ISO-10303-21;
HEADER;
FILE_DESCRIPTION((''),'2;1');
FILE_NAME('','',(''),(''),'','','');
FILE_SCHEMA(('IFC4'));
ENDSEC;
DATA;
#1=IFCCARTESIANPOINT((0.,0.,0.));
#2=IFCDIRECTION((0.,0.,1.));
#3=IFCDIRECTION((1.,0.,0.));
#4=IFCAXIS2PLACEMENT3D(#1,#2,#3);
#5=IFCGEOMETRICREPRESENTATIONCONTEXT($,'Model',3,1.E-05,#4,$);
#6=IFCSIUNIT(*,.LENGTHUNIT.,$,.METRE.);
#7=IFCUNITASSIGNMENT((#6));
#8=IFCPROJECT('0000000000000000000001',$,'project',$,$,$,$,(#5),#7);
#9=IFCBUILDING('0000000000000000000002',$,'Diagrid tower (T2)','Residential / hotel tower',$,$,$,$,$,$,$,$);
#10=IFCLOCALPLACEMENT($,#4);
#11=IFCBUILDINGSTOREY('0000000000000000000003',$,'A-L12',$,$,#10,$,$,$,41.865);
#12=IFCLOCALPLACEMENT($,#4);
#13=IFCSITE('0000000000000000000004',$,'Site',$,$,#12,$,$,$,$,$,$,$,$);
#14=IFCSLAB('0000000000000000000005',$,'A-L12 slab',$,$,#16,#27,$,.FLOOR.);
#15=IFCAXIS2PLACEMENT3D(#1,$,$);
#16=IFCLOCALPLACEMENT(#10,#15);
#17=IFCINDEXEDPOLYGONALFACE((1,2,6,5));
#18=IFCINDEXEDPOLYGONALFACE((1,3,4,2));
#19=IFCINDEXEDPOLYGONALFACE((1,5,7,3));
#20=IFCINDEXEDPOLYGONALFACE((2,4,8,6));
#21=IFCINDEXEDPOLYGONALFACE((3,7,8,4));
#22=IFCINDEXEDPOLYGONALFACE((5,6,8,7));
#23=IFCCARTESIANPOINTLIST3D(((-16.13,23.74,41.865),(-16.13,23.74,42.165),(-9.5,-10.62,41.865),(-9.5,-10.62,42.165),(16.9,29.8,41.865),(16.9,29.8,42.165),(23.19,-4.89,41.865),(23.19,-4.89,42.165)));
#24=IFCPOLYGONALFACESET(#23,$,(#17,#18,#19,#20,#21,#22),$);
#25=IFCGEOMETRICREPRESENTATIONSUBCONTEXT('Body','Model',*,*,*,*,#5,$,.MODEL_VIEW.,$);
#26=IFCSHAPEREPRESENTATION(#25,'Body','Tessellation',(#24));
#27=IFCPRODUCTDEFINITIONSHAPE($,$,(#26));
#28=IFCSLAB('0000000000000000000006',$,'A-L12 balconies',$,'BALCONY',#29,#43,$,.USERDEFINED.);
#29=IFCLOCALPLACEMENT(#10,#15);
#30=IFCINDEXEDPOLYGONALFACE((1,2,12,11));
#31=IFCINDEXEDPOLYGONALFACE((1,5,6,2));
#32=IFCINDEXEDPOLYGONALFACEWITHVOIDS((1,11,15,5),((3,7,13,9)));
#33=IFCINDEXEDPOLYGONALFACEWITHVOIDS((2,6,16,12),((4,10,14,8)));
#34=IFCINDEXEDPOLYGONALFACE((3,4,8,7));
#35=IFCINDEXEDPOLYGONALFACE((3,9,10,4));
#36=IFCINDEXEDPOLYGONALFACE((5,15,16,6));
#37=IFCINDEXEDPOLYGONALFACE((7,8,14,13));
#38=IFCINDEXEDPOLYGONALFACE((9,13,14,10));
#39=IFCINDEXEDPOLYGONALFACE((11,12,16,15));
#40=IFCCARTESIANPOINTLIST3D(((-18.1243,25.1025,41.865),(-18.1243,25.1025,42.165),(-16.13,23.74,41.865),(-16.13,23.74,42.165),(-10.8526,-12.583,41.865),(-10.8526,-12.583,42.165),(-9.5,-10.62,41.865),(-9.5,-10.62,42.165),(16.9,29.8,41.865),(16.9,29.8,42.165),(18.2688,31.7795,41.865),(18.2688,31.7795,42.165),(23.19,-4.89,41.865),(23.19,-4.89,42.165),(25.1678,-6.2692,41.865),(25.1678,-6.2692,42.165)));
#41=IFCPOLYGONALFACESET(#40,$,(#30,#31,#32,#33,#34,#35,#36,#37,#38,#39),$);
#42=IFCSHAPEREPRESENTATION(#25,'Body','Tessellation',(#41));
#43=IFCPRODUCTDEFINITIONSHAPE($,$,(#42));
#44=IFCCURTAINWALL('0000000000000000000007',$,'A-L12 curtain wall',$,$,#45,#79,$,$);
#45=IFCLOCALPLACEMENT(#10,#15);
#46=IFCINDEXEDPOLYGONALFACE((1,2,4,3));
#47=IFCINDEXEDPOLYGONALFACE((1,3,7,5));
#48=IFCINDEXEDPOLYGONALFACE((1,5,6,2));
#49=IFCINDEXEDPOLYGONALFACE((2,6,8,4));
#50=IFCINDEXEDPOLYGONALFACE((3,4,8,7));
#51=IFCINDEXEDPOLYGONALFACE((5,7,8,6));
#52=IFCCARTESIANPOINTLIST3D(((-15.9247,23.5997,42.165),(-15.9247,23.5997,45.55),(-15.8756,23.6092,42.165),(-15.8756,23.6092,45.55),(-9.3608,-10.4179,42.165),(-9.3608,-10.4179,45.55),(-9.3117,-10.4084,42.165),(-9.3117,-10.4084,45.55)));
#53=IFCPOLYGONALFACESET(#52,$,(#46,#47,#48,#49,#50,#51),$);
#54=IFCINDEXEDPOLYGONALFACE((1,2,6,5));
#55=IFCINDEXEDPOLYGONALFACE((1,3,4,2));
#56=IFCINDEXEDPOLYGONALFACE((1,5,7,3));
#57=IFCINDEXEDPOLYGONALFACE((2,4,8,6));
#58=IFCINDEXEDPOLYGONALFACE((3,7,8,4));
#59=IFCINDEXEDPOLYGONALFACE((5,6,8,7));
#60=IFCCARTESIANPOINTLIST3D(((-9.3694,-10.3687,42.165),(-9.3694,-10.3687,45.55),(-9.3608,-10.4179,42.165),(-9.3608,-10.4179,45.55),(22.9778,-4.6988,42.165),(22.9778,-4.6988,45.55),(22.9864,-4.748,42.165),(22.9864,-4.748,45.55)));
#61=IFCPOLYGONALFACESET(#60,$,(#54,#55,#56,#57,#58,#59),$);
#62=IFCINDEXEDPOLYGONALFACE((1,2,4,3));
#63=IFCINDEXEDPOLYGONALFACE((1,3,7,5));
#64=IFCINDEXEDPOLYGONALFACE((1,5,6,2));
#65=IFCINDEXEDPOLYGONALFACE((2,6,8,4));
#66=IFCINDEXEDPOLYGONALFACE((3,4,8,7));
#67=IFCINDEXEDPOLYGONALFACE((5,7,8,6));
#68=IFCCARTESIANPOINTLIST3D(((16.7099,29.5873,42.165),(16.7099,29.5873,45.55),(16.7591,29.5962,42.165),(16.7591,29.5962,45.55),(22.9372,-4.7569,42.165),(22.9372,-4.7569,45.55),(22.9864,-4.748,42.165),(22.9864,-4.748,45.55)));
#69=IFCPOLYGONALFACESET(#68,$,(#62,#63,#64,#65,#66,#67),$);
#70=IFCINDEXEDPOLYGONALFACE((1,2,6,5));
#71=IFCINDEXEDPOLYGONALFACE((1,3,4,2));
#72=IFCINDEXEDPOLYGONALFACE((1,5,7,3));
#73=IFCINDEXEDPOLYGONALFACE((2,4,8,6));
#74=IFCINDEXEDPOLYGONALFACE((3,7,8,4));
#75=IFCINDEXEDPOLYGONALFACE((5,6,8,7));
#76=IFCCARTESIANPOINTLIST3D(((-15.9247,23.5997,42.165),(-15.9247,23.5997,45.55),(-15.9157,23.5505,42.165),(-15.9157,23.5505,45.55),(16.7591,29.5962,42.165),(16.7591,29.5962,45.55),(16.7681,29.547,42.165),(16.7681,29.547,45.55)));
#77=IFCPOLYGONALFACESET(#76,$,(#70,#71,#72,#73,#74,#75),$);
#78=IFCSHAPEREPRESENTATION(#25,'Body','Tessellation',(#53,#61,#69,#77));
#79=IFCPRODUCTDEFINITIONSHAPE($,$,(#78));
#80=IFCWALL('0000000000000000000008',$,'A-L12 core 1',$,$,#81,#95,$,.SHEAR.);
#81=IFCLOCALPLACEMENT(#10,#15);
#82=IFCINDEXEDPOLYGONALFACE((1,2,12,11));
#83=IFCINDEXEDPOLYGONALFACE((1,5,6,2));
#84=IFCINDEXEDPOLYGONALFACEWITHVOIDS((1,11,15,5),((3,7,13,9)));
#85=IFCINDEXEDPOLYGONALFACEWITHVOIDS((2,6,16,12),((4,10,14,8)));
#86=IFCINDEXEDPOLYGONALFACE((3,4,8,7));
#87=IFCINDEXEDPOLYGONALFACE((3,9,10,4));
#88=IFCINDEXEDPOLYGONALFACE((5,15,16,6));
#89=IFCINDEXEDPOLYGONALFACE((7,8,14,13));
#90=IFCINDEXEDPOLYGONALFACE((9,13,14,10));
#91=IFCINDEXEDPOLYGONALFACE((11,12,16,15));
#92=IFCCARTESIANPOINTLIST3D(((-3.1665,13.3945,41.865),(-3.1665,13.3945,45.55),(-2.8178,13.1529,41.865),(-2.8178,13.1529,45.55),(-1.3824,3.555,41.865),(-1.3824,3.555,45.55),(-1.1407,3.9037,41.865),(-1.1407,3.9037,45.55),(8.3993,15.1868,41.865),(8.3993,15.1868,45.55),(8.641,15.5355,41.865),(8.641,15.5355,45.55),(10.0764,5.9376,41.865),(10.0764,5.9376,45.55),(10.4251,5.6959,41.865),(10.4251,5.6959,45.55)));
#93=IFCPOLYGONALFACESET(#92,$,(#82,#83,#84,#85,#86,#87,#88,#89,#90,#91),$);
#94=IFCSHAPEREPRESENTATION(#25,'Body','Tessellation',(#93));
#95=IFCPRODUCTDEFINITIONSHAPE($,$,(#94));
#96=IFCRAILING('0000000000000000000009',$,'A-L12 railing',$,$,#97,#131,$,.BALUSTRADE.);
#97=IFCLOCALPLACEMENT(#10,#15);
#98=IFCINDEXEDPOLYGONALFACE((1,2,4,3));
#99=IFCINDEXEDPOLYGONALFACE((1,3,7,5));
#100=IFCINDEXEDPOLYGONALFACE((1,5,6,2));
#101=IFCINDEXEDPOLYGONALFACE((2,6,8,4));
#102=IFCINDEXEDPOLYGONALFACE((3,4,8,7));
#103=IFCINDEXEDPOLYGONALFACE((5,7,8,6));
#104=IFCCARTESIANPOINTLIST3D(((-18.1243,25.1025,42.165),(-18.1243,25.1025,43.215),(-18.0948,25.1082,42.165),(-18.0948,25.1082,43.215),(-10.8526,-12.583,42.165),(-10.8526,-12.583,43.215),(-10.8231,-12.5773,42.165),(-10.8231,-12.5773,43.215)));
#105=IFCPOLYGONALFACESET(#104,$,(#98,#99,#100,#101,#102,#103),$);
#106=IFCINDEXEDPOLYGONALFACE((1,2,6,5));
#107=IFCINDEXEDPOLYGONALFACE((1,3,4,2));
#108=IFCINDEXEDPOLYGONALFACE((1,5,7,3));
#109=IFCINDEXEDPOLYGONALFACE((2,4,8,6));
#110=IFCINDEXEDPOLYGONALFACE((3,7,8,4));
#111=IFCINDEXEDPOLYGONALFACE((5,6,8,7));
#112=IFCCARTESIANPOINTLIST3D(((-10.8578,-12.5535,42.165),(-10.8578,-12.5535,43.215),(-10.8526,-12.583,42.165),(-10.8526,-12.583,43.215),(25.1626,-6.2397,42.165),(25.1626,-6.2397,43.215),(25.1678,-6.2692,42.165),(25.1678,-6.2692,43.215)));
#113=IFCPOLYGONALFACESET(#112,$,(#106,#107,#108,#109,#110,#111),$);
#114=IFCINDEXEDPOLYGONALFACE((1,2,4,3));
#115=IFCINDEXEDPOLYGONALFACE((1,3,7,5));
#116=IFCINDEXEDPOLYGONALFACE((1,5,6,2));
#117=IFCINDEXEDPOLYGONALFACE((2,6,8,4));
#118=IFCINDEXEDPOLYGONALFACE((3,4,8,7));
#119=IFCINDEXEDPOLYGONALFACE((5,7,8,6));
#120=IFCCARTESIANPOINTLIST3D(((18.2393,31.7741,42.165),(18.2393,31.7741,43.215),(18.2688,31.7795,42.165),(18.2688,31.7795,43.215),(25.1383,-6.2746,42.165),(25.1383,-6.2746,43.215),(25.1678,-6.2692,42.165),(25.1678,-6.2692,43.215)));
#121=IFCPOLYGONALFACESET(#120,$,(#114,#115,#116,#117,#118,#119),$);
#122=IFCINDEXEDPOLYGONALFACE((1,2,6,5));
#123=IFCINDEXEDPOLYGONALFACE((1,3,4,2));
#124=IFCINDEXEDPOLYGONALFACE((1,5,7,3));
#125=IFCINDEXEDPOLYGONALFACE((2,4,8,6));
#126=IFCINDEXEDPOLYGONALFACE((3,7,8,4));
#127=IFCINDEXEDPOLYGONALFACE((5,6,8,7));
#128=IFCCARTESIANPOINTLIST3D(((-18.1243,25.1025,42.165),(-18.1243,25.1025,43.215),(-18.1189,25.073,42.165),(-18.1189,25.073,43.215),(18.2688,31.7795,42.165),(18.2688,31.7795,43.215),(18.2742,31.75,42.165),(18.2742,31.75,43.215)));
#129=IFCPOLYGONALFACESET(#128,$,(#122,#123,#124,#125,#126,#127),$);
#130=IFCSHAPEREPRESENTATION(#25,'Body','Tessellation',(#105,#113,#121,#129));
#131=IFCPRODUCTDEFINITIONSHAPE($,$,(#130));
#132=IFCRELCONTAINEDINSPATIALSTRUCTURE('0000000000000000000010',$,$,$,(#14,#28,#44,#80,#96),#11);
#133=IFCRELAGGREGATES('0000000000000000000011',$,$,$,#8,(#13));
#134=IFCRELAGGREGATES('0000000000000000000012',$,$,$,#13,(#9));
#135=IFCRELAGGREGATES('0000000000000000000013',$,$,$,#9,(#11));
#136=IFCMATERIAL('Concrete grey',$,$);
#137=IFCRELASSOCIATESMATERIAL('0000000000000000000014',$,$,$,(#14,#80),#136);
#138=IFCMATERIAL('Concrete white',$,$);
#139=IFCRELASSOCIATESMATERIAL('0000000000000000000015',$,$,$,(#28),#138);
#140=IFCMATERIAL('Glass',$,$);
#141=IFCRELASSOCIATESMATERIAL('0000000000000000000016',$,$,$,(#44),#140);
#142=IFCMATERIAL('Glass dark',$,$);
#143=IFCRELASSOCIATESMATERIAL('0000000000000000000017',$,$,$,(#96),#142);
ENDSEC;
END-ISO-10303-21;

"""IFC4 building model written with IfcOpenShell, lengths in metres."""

from ifc_helpers import new_model, si_unit, frame, origin_with_axes, place, context, subcontext, project, spatial, polyline, outline, extrude, material, element, save


model = new_model("IFC4")

# Units and contexts
model_context = context("Model", 3, precision=1e-05, world=origin_with_axes())
body_context = subcontext(model_context, "Body", "Model", "MODEL_VIEW")
ifc_project = project(units=[si_unit("LENGTHUNIT", "METRE")], contexts=[model_context])

# Site, building, storey
site_placement = place(None, origin_with_axes())
site = spatial("IfcSite", under=ifc_project, at=site_placement, Name="Site")
building = spatial("IfcBuilding", under=site, Name="Diagrid tower (T2)", Description="Residential / hotel tower")
storey_placement = place(None, origin_with_axes())
storey = spatial("IfcBuildingStorey", under=building, at=storey_placement, Name="A-L12", Elevation=41.865)

# Slabs
ifc_material_1 = material(Name="Concrete grey")
slab_1_placement = place(storey_placement, origin_with_axes())
element("IfcSlab", 1, at=slab_1_placement, inside=storey, material=ifc_material_1, Name="A-L12 slab", PredefinedType="FLOOR", context=body_context, shape_type="SweptSolid", body=[
    extrude(outline(polyline([(-16.13, 23.74), (-9.5, -10.62), (23.19, -4.89), (16.9, 29.8), (-16.13, 23.74)])), frame((0.0, 0.0, 41.865), z_axis=(0.0, 0.0, 1.0), x_axis=(1.0, 0.0, 0.0)), (0.0, 0.0, 1.0), 0.3),
])
ifc_material_2 = material(Name="Concrete white")
slab_2_placement = place(storey_placement, origin_with_axes())
element("IfcSlab", 2, at=slab_2_placement, inside=storey, material=ifc_material_2, Name="A-L12 balconies", ObjectType="BALCONY", PredefinedType="USERDEFINED", context=body_context, shape_type="SweptSolid", body=[
    extrude(outline(polyline([(-18.1243, 25.1025), (-10.8526, -12.583), (25.1678, -6.2692), (18.2688, 31.7795), (-18.1243, 25.1025)]), holes=[polyline([(-16.13, 23.74), (-9.5, -10.62), (23.19, -4.89), (16.9, 29.8), (-16.13, 23.74)])]), frame((0.0, 0.0, 41.865), z_axis=(0.0, 0.0, 1.0), x_axis=(1.0, 0.0, 0.0)), (0.0, 0.0, 1.0), 0.3),
])

# Curtain wall
ifc_material_3 = material(Name="Glass")
curtain_wall_placement = place(storey_placement, origin_with_axes())
element("IfcCurtainWall", 3, at=curtain_wall_placement, inside=storey, material=ifc_material_3, Name="A-L12 curtain wall", context=body_context, shape_type="SweptSolid", body=[
    extrude(outline(polyline([(-15.9247, 23.5997), (-9.3608, -10.4179), (-9.3117, -10.4084), (-15.8756, 23.6092), (-15.9247, 23.5997)])), frame((0.0, 0.0, 42.165), z_axis=(0.0, 0.0, 1.0), x_axis=(1.0, 0.0, 0.0)), (0.0, 0.0, 1.0), 3.385),
    extrude(outline(polyline([(-9.3608, -10.4179), (22.9864, -4.748), (22.9778, -4.6988), (-9.3694, -10.3687), (-9.3608, -10.4179)])), frame((0.0, 0.0, 42.165), z_axis=(0.0, 0.0, 1.0), x_axis=(1.0, 0.0, 0.0)), (0.0, 0.0, 1.0), 3.385),
    extrude(outline(polyline([(22.9864, -4.748), (16.7591, 29.5962), (16.7099, 29.5873), (22.9372, -4.7569), (22.9864, -4.748)])), frame((0.0, 0.0, 42.165), z_axis=(0.0, 0.0, 1.0), x_axis=(1.0, 0.0, 0.0)), (0.0, 0.0, 1.0), 3.385),
    extrude(outline(polyline([(16.7591, 29.5962), (-15.9247, 23.5997), (-15.9157, 23.5505), (16.7681, 29.547), (16.7591, 29.5962)])), frame((0.0, 0.0, 42.165), z_axis=(0.0, 0.0, 1.0), x_axis=(1.0, 0.0, 0.0)), (0.0, 0.0, 1.0), 3.385),
])

# Wall
wall_placement = place(storey_placement, origin_with_axes())
element("IfcWall", 4, at=wall_placement, inside=storey, material=ifc_material_1, Name="A-L12 core 1", PredefinedType="SHEAR", context=body_context, shape_type="SweptSolid", body=[
    extrude(outline(polyline([(10.4251, 5.6959), (8.641, 15.5355), (-3.1665, 13.3945), (-1.3824, 3.555), (10.4251, 5.6959)]), holes=[polyline([(10.0764, 5.9376), (8.3993, 15.1868), (-2.8178, 13.1529), (-1.1407, 3.9037), (10.0764, 5.9376)])]), frame((0.0, 0.0, 41.865), z_axis=(0.0, 0.0, 1.0), x_axis=(1.0, 0.0, 0.0)), (0.0, 0.0, 1.0), 3.685),
])

# Railing
ifc_material_4 = material(Name="Glass dark")
railing_placement = place(storey_placement, origin_with_axes())
element("IfcRailing", 5, at=railing_placement, inside=storey, material=ifc_material_4, Name="A-L12 railing", PredefinedType="BALUSTRADE", context=body_context, shape_type="SweptSolid", body=[
    extrude(outline(polyline([(-18.1243, 25.1025), (-10.8526, -12.583), (-10.8231, -12.5773), (-18.0948, 25.1082), (-18.1243, 25.1025)])), frame((0.0, 0.0, 42.165), z_axis=(0.0, 0.0, 1.0), x_axis=(1.0, 0.0, 0.0)), (0.0, 0.0, 1.0), 1.05),
    extrude(outline(polyline([(-10.8526, -12.583), (25.1678, -6.2692), (25.1626, -6.2397), (-10.8578, -12.5535), (-10.8526, -12.583)])), frame((0.0, 0.0, 42.165), z_axis=(0.0, 0.0, 1.0), x_axis=(1.0, 0.0, 0.0)), (0.0, 0.0, 1.0), 1.05),
    extrude(outline(polyline([(25.1678, -6.2692), (18.2688, 31.7795), (18.2393, 31.7741), (25.1383, -6.2746), (25.1678, -6.2692)])), frame((0.0, 0.0, 42.165), z_axis=(0.0, 0.0, 1.0), x_axis=(1.0, 0.0, 0.0)), (0.0, 0.0, 1.0), 1.05),
    extrude(outline(polyline([(18.2688, 31.7795), (-18.1243, 25.1025), (-18.1189, 25.073), (18.2742, 31.75), (18.2688, 31.7795)])), frame((0.0, 0.0, 42.165), z_axis=(0.0, 0.0, 1.0), x_axis=(1.0, 0.0, 0.0)), (0.0, 0.0, 1.0), 1.05),
])

save(model, "model.ifc")
